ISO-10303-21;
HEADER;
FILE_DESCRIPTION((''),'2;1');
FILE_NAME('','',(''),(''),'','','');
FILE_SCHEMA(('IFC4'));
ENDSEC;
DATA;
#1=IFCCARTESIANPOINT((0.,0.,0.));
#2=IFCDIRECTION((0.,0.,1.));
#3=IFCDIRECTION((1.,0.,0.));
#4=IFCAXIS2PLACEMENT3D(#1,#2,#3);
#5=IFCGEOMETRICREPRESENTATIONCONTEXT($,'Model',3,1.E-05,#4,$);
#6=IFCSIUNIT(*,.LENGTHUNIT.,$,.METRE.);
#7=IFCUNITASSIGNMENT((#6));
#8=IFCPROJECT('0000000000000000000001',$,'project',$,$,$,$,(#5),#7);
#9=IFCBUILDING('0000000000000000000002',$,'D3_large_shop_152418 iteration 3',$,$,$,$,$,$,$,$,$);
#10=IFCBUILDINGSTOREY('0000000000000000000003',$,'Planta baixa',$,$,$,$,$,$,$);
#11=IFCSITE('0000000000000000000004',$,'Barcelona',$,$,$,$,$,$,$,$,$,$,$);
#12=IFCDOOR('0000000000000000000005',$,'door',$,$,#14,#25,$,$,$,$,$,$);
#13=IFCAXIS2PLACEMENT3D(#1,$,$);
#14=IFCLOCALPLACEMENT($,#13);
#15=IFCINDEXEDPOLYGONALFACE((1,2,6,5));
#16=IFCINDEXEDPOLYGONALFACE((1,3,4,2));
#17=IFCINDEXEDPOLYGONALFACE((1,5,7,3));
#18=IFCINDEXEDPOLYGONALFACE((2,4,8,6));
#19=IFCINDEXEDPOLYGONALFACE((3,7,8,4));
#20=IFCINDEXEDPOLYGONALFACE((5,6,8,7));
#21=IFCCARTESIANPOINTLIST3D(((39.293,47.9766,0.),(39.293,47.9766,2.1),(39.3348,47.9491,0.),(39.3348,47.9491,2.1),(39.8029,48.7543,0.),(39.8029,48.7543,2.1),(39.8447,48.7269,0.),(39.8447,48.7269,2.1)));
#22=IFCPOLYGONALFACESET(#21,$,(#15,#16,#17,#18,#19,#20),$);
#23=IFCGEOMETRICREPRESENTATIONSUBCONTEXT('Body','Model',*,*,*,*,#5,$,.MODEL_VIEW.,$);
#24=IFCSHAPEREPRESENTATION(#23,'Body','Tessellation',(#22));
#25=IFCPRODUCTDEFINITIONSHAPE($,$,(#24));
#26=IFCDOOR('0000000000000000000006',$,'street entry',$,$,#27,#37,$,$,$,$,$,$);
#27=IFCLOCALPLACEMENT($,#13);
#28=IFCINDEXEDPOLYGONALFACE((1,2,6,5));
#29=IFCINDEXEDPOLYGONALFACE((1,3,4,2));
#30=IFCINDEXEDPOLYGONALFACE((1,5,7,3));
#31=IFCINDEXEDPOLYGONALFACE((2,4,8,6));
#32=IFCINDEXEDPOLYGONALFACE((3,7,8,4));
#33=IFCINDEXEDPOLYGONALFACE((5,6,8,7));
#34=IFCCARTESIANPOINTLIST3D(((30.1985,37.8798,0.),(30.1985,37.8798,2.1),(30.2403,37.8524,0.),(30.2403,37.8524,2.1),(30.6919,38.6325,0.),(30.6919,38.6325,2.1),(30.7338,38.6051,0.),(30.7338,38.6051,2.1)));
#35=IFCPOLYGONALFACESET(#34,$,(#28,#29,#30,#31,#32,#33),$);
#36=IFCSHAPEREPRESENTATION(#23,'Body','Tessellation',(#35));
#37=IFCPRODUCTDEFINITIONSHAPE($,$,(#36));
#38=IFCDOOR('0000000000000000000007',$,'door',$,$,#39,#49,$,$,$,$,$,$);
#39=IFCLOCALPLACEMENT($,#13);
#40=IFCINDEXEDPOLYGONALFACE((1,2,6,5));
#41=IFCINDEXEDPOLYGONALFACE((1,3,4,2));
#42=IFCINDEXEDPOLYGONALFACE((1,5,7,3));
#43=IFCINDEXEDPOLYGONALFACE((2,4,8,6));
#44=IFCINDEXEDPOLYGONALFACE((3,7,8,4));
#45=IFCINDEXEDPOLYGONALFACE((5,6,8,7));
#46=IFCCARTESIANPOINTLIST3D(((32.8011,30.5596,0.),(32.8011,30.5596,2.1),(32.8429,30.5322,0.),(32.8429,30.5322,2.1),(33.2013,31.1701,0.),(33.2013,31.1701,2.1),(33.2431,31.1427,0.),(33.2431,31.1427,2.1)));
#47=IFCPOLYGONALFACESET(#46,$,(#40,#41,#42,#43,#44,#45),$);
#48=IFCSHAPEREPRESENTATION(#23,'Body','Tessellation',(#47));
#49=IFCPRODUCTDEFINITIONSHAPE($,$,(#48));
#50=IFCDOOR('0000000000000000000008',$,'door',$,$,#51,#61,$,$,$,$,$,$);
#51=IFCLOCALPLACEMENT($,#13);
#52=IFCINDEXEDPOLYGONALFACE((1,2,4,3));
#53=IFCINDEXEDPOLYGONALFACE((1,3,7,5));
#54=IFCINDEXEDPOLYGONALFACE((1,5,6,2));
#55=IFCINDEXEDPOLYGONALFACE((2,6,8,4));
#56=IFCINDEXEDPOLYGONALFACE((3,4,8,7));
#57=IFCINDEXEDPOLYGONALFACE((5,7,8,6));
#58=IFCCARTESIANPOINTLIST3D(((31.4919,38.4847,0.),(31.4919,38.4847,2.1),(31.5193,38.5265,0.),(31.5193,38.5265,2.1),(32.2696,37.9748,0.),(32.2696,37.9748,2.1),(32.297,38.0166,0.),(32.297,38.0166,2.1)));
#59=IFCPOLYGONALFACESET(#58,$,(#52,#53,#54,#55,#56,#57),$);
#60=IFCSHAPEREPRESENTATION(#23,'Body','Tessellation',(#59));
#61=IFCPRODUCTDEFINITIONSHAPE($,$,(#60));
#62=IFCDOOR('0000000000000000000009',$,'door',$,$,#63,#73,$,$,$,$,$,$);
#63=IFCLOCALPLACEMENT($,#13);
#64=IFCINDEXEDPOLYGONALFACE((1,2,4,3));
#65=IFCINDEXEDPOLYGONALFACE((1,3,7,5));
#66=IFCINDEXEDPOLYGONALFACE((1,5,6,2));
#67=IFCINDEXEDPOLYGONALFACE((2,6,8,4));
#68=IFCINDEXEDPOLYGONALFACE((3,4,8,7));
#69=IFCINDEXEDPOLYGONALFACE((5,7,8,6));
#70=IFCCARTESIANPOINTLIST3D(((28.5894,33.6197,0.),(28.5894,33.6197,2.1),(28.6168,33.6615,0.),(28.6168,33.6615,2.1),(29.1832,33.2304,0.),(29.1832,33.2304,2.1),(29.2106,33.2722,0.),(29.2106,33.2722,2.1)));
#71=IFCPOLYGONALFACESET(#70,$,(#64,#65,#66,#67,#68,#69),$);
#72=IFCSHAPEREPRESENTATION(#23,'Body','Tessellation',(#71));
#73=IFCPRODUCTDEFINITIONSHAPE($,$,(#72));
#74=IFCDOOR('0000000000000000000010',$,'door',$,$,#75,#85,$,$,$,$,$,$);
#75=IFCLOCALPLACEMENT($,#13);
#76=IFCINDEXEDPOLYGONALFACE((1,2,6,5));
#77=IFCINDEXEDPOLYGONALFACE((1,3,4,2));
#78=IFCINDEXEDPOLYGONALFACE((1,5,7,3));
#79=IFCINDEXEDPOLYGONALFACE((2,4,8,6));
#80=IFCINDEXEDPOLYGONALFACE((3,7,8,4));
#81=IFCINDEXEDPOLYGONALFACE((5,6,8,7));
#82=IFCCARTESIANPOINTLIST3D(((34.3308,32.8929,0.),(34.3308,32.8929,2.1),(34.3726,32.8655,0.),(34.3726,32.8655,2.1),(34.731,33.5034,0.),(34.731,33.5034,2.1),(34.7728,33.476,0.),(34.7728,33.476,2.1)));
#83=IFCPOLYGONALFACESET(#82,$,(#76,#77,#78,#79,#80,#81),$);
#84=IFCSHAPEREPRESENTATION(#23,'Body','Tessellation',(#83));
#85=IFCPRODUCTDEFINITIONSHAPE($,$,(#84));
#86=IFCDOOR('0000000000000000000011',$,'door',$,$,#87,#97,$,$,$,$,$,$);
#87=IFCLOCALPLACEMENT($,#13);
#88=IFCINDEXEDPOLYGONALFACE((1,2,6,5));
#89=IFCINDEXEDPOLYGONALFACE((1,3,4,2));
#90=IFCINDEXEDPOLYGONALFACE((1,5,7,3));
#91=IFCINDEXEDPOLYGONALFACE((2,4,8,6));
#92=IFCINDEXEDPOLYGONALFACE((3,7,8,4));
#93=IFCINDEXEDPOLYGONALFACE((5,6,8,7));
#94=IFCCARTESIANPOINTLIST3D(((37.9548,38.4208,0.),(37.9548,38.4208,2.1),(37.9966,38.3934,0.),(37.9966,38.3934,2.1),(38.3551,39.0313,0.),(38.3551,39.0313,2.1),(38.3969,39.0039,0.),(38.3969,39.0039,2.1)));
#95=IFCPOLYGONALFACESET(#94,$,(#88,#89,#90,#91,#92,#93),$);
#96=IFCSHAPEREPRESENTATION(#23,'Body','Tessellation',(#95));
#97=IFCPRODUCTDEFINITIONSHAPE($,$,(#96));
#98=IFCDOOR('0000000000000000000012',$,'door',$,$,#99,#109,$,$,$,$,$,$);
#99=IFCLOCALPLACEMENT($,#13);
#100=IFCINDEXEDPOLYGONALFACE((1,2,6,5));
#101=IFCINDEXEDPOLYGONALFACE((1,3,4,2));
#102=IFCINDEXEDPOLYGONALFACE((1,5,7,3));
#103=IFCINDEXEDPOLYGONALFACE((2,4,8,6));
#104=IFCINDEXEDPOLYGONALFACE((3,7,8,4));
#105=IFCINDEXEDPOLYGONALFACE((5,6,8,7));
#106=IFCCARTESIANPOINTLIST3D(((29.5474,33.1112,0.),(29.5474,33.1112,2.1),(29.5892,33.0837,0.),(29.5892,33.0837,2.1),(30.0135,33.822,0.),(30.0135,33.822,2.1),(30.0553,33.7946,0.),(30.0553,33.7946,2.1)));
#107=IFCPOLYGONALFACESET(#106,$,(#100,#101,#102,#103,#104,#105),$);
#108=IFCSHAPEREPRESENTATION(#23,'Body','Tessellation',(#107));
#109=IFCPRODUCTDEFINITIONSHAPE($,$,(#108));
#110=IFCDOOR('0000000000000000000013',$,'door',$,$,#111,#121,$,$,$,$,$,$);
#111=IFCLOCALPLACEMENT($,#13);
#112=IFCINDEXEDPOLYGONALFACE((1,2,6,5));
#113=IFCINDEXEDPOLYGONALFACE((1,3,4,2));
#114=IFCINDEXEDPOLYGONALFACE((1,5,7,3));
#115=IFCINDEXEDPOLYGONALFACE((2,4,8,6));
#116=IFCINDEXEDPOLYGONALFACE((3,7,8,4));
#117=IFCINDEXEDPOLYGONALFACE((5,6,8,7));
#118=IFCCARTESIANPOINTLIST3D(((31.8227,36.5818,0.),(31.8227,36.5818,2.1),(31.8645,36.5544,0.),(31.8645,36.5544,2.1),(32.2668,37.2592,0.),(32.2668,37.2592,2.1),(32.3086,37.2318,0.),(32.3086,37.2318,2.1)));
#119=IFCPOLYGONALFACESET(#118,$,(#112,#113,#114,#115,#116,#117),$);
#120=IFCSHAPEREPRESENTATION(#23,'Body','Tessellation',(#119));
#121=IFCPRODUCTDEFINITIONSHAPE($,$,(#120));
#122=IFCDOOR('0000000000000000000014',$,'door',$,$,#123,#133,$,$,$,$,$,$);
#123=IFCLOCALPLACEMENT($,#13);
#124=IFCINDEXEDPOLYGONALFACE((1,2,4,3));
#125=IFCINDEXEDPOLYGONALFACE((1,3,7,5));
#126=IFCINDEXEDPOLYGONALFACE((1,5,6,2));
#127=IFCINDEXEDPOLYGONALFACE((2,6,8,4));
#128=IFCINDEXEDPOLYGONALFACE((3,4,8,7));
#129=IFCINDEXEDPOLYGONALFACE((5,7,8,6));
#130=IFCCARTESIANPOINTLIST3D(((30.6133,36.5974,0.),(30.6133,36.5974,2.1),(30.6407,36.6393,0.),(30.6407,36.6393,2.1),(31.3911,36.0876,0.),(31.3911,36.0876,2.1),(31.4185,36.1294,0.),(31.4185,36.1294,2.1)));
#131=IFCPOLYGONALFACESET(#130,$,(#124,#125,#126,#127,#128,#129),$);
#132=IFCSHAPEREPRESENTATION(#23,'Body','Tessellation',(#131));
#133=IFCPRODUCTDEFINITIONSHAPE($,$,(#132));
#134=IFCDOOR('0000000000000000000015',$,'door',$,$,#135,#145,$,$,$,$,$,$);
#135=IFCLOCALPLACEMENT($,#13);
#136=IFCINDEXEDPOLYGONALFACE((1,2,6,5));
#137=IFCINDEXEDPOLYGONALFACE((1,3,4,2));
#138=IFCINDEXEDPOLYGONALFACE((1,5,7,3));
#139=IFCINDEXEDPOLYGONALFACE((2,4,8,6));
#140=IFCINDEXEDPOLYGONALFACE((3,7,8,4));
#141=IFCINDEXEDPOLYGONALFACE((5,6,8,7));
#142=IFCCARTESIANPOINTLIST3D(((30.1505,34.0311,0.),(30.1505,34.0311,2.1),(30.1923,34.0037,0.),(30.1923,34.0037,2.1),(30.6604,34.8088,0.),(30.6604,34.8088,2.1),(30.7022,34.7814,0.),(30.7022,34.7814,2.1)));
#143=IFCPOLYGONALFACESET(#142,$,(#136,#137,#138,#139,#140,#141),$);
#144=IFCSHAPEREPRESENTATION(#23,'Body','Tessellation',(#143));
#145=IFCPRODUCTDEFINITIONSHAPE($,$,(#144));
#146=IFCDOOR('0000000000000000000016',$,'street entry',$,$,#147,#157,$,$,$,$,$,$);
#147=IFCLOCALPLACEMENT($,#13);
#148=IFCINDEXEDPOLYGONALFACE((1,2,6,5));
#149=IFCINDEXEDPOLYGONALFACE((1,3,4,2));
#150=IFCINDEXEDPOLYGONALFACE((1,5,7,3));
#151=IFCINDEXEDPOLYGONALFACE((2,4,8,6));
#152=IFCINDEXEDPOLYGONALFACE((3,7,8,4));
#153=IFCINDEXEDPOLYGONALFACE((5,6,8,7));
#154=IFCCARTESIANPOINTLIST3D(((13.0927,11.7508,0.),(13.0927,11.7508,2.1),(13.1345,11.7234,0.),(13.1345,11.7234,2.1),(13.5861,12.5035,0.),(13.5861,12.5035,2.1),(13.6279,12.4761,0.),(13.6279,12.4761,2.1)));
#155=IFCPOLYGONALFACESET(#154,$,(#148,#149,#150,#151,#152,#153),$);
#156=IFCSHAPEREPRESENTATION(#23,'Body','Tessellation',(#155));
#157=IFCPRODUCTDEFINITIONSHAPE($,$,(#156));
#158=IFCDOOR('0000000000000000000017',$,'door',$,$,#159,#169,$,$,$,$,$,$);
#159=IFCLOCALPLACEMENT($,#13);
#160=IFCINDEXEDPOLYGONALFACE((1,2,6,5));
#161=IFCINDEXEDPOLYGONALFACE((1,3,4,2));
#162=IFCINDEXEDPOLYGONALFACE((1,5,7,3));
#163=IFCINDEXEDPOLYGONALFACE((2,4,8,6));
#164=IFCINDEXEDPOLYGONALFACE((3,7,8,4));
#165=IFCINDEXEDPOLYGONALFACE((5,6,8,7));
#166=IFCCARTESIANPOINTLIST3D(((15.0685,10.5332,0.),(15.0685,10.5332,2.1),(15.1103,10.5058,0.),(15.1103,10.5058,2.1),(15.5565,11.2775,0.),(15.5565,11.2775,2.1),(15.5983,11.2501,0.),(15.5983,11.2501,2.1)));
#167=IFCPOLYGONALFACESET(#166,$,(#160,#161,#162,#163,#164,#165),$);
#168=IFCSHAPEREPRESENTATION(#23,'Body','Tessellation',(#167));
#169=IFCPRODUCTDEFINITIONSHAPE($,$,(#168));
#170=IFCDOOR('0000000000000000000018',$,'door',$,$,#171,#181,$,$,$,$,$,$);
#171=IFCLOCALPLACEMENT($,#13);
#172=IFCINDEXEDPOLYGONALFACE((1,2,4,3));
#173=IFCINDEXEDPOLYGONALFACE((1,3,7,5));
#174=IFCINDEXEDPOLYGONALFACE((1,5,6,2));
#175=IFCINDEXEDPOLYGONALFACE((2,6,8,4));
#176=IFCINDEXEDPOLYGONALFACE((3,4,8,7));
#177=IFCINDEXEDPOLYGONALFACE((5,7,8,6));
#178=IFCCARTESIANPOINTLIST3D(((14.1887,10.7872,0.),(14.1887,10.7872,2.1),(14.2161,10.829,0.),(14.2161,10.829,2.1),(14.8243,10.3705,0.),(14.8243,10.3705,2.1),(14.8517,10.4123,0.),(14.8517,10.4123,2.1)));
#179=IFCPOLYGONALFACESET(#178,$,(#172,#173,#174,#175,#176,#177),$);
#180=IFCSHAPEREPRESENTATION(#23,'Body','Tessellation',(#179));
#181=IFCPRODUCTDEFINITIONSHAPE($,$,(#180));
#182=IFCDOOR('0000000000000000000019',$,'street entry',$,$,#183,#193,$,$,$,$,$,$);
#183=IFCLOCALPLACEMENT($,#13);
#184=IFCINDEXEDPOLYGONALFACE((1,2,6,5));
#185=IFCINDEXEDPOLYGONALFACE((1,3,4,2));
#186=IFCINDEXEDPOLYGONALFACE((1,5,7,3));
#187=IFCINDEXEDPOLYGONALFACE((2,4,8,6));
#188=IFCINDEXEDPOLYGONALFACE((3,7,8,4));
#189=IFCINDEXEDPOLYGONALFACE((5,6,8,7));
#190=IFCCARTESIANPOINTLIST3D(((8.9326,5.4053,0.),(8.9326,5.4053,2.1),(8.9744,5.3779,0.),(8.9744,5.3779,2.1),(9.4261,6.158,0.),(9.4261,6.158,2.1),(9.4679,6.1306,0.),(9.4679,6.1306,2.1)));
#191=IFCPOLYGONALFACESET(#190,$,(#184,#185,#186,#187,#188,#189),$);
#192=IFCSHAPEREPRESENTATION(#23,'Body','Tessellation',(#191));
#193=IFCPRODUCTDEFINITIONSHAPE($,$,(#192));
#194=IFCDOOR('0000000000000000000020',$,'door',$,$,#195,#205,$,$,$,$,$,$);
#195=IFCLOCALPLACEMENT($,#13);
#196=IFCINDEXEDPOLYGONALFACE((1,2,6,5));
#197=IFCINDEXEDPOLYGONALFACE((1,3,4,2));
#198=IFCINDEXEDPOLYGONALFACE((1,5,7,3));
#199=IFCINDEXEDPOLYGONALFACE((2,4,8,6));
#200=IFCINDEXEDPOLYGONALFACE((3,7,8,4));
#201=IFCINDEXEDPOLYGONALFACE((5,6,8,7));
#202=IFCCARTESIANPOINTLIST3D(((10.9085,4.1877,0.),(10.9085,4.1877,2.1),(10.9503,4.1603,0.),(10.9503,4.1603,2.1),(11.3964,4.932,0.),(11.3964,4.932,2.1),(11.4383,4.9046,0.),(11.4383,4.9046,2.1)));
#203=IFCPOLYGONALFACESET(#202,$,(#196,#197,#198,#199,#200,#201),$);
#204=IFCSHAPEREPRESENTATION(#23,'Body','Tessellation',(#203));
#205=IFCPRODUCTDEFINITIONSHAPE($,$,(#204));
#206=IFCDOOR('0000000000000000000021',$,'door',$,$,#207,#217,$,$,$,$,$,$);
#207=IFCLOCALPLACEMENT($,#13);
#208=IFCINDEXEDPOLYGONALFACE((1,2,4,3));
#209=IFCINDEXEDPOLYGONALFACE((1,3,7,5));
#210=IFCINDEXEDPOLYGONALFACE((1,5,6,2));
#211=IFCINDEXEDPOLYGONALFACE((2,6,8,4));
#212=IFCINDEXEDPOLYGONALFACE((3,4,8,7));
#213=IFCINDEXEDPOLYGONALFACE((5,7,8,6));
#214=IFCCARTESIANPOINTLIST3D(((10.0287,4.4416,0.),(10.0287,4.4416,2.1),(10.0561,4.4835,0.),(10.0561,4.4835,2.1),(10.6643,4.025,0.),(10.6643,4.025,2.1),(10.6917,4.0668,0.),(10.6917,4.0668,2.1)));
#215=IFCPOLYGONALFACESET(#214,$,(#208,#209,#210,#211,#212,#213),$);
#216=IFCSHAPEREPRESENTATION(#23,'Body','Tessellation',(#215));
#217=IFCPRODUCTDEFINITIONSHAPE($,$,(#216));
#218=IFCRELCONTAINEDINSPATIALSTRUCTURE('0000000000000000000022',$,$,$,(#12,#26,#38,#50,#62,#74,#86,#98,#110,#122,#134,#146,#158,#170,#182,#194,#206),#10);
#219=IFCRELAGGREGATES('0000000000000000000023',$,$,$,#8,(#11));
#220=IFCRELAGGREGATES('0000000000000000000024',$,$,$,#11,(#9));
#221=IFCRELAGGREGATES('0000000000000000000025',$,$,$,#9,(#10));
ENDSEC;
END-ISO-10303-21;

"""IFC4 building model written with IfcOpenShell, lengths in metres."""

from ifc_helpers import new_model, si_unit, origin, origin_with_axes, place, context, subcontext, project, spatial, polyline, outline, extrude, element, save


model = new_model("IFC4")

# Units and contexts
model_context = context("Model", 3, precision=1e-05, world=origin_with_axes())
body_context = subcontext(model_context, "Body", "Model", "MODEL_VIEW")
ifc_project = project(units=[si_unit("LENGTHUNIT", "METRE")], contexts=[model_context])

# Site, building, storey
site = spatial("IfcSite", under=ifc_project, Name="Barcelona")
building = spatial("IfcBuilding", under=site, Name="D3_large_shop_152418 iteration 3")
storey = spatial("IfcBuildingStorey", under=building, Name="Planta baixa")

# Doors
door_1_placement = place(None, origin_with_axes())
element("IfcDoor", 1, at=door_1_placement, inside=storey, Name="door", context=body_context, shape_type="SweptSolid", body=[
    extrude(outline(polyline([(39.8447, 48.7269), (39.3348, 47.9491), (39.293, 47.9766), (39.8029, 48.7543), (39.8447, 48.7269)])), origin(), (0.0, 0.0, 1.0), 2.1),
])
door_2_placement = place(None, origin_with_axes())
element("IfcDoor", 2, at=door_2_placement, inside=storey, Name="street entry", context=body_context, shape_type="SweptSolid", body=[
    extrude(outline(polyline([(30.7338, 38.6051), (30.2403, 37.8524), (30.1985, 37.8798), (30.6919, 38.6325), (30.7338, 38.6051)])), origin(), (0.0, 0.0, 1.0), 2.1),
])
door_3_placement = place(None, origin_with_axes())
element("IfcDoor", 3, at=door_3_placement, inside=storey, Name="door", context=body_context, shape_type="SweptSolid", body=[
    extrude(outline(polyline([(32.8011, 30.5596), (33.2013, 31.1701), (33.2431, 31.1427), (32.8429, 30.5322), (32.8011, 30.5596)])), origin(), (0.0, 0.0, 1.0), 2.1),
])
door_4_placement = place(None, origin_with_axes())
element("IfcDoor", 4, at=door_4_placement, inside=storey, Name="door", context=body_context, shape_type="SweptSolid", body=[
    extrude(outline(polyline([(32.2696, 37.9748), (31.4919, 38.4847), (31.5193, 38.5265), (32.297, 38.0166), (32.2696, 37.9748)])), origin(), (0.0, 0.0, 1.0), 2.1),
])
door_5_placement = place(None, origin_with_axes())
element("IfcDoor", 5, at=door_5_placement, inside=storey, Name="door", context=body_context, shape_type="SweptSolid", body=[
    extrude(outline(polyline([(29.1832, 33.2304), (28.5894, 33.6197), (28.6168, 33.6615), (29.2106, 33.2722), (29.1832, 33.2304)])), origin(), (0.0, 0.0, 1.0), 2.1),
])
door_6_placement = place(None, origin_with_axes())
element("IfcDoor", 6, at=door_6_placement, inside=storey, Name="door", context=body_context, shape_type="SweptSolid", body=[
    extrude(outline(polyline([(34.7728, 33.476), (34.3726, 32.8655), (34.3308, 32.8929), (34.731, 33.5034), (34.7728, 33.476)])), origin(), (0.0, 0.0, 1.0), 2.1),
])
door_7_placement = place(None, origin_with_axes())
element("IfcDoor", 7, at=door_7_placement, inside=storey, Name="door", context=body_context, shape_type="SweptSolid", body=[
    extrude(outline(polyline([(38.3969, 39.0039), (37.9966, 38.3934), (37.9548, 38.4208), (38.3551, 39.0313), (38.3969, 39.0039)])), origin(), (0.0, 0.0, 1.0), 2.1),
])
door_8_placement = place(None, origin_with_axes())
element("IfcDoor", 8, at=door_8_placement, inside=storey, Name="door", context=body_context, shape_type="SweptSolid", body=[
    extrude(outline(polyline([(30.0553, 33.7946), (29.5892, 33.0837), (29.5474, 33.1112), (30.0135, 33.822), (30.0553, 33.7946)])), origin(), (0.0, 0.0, 1.0), 2.1),
])
door_9_placement = place(None, origin_with_axes())
element("IfcDoor", 9, at=door_9_placement, inside=storey, Name="door", context=body_context, shape_type="SweptSolid", body=[
    extrude(outline(polyline([(32.3086, 37.2318), (31.8645, 36.5544), (31.8227, 36.5818), (32.2668, 37.2592), (32.3086, 37.2318)])), origin(), (0.0, 0.0, 1.0), 2.1),
])
door_10_placement = place(None, origin_with_axes())
element("IfcDoor", 10, at=door_10_placement, inside=storey, Name="door", context=body_context, shape_type="SweptSolid", body=[
    extrude(outline(polyline([(30.6407, 36.6393), (31.4185, 36.1294), (31.3911, 36.0876), (30.6133, 36.5974), (30.6407, 36.6393)])), origin(), (0.0, 0.0, 1.0), 2.1),
])
door_11_placement = place(None, origin_with_axes())
element("IfcDoor", 11, at=door_11_placement, inside=storey, Name="door", context=body_context, shape_type="SweptSolid", body=[
    extrude(outline(polyline([(30.7022, 34.7814), (30.1923, 34.0037), (30.1505, 34.0311), (30.6604, 34.8088), (30.7022, 34.7814)])), origin(), (0.0, 0.0, 1.0), 2.1),
])
door_12_placement = place(None, origin_with_axes())
element("IfcDoor", 12, at=door_12_placement, inside=storey, Name="street entry", context=body_context, shape_type="SweptSolid", body=[
    extrude(outline(polyline([(13.6279, 12.4761), (13.1345, 11.7234), (13.0927, 11.7508), (13.5861, 12.5035), (13.6279, 12.4761)])), origin(), (0.0, 0.0, 1.0), 2.1),
])
door_13_placement = place(None, origin_with_axes())
element("IfcDoor", 13, at=door_13_placement, inside=storey, Name="door", context=body_context, shape_type="SweptSolid", body=[
    extrude(outline(polyline([(15.5983, 11.2501), (15.1103, 10.5058), (15.0685, 10.5332), (15.5565, 11.2775), (15.5983, 11.2501)])), origin(), (0.0, 0.0, 1.0), 2.1),
])
door_14_placement = place(None, origin_with_axes())
element("IfcDoor", 14, at=door_14_placement, inside=storey, Name="door", context=body_context, shape_type="SweptSolid", body=[
    extrude(outline(polyline([(14.8243, 10.3705), (14.1887, 10.7872), (14.2161, 10.829), (14.8517, 10.4123), (14.8243, 10.3705)])), origin(), (0.0, 0.0, 1.0), 2.1),
])
door_15_placement = place(None, origin_with_axes())
element("IfcDoor", 15, at=door_15_placement, inside=storey, Name="street entry", context=body_context, shape_type="SweptSolid", body=[
    extrude(outline(polyline([(9.4679, 6.1306), (8.9744, 5.3779), (8.9326, 5.4053), (9.4261, 6.158), (9.4679, 6.1306)])), origin(), (0.0, 0.0, 1.0), 2.1),
])
door_16_placement = place(None, origin_with_axes())
element("IfcDoor", 16, at=door_16_placement, inside=storey, Name="door", context=body_context, shape_type="SweptSolid", body=[
    extrude(outline(polyline([(11.4383, 4.9046), (10.9503, 4.1603), (10.9085, 4.1877), (11.3964, 4.932), (11.4383, 4.9046)])), origin(), (0.0, 0.0, 1.0), 2.1),
])
door_17_placement = place(None, origin_with_axes())
element("IfcDoor", 17, at=door_17_placement, inside=storey, Name="door", context=body_context, shape_type="SweptSolid", body=[
    extrude(outline(polyline([(10.6643, 4.025), (10.0287, 4.4416), (10.0561, 4.4835), (10.6917, 4.0668), (10.6643, 4.025)])), origin(), (0.0, 0.0, 1.0), 2.1),
])

save(model, "model.ifc")
